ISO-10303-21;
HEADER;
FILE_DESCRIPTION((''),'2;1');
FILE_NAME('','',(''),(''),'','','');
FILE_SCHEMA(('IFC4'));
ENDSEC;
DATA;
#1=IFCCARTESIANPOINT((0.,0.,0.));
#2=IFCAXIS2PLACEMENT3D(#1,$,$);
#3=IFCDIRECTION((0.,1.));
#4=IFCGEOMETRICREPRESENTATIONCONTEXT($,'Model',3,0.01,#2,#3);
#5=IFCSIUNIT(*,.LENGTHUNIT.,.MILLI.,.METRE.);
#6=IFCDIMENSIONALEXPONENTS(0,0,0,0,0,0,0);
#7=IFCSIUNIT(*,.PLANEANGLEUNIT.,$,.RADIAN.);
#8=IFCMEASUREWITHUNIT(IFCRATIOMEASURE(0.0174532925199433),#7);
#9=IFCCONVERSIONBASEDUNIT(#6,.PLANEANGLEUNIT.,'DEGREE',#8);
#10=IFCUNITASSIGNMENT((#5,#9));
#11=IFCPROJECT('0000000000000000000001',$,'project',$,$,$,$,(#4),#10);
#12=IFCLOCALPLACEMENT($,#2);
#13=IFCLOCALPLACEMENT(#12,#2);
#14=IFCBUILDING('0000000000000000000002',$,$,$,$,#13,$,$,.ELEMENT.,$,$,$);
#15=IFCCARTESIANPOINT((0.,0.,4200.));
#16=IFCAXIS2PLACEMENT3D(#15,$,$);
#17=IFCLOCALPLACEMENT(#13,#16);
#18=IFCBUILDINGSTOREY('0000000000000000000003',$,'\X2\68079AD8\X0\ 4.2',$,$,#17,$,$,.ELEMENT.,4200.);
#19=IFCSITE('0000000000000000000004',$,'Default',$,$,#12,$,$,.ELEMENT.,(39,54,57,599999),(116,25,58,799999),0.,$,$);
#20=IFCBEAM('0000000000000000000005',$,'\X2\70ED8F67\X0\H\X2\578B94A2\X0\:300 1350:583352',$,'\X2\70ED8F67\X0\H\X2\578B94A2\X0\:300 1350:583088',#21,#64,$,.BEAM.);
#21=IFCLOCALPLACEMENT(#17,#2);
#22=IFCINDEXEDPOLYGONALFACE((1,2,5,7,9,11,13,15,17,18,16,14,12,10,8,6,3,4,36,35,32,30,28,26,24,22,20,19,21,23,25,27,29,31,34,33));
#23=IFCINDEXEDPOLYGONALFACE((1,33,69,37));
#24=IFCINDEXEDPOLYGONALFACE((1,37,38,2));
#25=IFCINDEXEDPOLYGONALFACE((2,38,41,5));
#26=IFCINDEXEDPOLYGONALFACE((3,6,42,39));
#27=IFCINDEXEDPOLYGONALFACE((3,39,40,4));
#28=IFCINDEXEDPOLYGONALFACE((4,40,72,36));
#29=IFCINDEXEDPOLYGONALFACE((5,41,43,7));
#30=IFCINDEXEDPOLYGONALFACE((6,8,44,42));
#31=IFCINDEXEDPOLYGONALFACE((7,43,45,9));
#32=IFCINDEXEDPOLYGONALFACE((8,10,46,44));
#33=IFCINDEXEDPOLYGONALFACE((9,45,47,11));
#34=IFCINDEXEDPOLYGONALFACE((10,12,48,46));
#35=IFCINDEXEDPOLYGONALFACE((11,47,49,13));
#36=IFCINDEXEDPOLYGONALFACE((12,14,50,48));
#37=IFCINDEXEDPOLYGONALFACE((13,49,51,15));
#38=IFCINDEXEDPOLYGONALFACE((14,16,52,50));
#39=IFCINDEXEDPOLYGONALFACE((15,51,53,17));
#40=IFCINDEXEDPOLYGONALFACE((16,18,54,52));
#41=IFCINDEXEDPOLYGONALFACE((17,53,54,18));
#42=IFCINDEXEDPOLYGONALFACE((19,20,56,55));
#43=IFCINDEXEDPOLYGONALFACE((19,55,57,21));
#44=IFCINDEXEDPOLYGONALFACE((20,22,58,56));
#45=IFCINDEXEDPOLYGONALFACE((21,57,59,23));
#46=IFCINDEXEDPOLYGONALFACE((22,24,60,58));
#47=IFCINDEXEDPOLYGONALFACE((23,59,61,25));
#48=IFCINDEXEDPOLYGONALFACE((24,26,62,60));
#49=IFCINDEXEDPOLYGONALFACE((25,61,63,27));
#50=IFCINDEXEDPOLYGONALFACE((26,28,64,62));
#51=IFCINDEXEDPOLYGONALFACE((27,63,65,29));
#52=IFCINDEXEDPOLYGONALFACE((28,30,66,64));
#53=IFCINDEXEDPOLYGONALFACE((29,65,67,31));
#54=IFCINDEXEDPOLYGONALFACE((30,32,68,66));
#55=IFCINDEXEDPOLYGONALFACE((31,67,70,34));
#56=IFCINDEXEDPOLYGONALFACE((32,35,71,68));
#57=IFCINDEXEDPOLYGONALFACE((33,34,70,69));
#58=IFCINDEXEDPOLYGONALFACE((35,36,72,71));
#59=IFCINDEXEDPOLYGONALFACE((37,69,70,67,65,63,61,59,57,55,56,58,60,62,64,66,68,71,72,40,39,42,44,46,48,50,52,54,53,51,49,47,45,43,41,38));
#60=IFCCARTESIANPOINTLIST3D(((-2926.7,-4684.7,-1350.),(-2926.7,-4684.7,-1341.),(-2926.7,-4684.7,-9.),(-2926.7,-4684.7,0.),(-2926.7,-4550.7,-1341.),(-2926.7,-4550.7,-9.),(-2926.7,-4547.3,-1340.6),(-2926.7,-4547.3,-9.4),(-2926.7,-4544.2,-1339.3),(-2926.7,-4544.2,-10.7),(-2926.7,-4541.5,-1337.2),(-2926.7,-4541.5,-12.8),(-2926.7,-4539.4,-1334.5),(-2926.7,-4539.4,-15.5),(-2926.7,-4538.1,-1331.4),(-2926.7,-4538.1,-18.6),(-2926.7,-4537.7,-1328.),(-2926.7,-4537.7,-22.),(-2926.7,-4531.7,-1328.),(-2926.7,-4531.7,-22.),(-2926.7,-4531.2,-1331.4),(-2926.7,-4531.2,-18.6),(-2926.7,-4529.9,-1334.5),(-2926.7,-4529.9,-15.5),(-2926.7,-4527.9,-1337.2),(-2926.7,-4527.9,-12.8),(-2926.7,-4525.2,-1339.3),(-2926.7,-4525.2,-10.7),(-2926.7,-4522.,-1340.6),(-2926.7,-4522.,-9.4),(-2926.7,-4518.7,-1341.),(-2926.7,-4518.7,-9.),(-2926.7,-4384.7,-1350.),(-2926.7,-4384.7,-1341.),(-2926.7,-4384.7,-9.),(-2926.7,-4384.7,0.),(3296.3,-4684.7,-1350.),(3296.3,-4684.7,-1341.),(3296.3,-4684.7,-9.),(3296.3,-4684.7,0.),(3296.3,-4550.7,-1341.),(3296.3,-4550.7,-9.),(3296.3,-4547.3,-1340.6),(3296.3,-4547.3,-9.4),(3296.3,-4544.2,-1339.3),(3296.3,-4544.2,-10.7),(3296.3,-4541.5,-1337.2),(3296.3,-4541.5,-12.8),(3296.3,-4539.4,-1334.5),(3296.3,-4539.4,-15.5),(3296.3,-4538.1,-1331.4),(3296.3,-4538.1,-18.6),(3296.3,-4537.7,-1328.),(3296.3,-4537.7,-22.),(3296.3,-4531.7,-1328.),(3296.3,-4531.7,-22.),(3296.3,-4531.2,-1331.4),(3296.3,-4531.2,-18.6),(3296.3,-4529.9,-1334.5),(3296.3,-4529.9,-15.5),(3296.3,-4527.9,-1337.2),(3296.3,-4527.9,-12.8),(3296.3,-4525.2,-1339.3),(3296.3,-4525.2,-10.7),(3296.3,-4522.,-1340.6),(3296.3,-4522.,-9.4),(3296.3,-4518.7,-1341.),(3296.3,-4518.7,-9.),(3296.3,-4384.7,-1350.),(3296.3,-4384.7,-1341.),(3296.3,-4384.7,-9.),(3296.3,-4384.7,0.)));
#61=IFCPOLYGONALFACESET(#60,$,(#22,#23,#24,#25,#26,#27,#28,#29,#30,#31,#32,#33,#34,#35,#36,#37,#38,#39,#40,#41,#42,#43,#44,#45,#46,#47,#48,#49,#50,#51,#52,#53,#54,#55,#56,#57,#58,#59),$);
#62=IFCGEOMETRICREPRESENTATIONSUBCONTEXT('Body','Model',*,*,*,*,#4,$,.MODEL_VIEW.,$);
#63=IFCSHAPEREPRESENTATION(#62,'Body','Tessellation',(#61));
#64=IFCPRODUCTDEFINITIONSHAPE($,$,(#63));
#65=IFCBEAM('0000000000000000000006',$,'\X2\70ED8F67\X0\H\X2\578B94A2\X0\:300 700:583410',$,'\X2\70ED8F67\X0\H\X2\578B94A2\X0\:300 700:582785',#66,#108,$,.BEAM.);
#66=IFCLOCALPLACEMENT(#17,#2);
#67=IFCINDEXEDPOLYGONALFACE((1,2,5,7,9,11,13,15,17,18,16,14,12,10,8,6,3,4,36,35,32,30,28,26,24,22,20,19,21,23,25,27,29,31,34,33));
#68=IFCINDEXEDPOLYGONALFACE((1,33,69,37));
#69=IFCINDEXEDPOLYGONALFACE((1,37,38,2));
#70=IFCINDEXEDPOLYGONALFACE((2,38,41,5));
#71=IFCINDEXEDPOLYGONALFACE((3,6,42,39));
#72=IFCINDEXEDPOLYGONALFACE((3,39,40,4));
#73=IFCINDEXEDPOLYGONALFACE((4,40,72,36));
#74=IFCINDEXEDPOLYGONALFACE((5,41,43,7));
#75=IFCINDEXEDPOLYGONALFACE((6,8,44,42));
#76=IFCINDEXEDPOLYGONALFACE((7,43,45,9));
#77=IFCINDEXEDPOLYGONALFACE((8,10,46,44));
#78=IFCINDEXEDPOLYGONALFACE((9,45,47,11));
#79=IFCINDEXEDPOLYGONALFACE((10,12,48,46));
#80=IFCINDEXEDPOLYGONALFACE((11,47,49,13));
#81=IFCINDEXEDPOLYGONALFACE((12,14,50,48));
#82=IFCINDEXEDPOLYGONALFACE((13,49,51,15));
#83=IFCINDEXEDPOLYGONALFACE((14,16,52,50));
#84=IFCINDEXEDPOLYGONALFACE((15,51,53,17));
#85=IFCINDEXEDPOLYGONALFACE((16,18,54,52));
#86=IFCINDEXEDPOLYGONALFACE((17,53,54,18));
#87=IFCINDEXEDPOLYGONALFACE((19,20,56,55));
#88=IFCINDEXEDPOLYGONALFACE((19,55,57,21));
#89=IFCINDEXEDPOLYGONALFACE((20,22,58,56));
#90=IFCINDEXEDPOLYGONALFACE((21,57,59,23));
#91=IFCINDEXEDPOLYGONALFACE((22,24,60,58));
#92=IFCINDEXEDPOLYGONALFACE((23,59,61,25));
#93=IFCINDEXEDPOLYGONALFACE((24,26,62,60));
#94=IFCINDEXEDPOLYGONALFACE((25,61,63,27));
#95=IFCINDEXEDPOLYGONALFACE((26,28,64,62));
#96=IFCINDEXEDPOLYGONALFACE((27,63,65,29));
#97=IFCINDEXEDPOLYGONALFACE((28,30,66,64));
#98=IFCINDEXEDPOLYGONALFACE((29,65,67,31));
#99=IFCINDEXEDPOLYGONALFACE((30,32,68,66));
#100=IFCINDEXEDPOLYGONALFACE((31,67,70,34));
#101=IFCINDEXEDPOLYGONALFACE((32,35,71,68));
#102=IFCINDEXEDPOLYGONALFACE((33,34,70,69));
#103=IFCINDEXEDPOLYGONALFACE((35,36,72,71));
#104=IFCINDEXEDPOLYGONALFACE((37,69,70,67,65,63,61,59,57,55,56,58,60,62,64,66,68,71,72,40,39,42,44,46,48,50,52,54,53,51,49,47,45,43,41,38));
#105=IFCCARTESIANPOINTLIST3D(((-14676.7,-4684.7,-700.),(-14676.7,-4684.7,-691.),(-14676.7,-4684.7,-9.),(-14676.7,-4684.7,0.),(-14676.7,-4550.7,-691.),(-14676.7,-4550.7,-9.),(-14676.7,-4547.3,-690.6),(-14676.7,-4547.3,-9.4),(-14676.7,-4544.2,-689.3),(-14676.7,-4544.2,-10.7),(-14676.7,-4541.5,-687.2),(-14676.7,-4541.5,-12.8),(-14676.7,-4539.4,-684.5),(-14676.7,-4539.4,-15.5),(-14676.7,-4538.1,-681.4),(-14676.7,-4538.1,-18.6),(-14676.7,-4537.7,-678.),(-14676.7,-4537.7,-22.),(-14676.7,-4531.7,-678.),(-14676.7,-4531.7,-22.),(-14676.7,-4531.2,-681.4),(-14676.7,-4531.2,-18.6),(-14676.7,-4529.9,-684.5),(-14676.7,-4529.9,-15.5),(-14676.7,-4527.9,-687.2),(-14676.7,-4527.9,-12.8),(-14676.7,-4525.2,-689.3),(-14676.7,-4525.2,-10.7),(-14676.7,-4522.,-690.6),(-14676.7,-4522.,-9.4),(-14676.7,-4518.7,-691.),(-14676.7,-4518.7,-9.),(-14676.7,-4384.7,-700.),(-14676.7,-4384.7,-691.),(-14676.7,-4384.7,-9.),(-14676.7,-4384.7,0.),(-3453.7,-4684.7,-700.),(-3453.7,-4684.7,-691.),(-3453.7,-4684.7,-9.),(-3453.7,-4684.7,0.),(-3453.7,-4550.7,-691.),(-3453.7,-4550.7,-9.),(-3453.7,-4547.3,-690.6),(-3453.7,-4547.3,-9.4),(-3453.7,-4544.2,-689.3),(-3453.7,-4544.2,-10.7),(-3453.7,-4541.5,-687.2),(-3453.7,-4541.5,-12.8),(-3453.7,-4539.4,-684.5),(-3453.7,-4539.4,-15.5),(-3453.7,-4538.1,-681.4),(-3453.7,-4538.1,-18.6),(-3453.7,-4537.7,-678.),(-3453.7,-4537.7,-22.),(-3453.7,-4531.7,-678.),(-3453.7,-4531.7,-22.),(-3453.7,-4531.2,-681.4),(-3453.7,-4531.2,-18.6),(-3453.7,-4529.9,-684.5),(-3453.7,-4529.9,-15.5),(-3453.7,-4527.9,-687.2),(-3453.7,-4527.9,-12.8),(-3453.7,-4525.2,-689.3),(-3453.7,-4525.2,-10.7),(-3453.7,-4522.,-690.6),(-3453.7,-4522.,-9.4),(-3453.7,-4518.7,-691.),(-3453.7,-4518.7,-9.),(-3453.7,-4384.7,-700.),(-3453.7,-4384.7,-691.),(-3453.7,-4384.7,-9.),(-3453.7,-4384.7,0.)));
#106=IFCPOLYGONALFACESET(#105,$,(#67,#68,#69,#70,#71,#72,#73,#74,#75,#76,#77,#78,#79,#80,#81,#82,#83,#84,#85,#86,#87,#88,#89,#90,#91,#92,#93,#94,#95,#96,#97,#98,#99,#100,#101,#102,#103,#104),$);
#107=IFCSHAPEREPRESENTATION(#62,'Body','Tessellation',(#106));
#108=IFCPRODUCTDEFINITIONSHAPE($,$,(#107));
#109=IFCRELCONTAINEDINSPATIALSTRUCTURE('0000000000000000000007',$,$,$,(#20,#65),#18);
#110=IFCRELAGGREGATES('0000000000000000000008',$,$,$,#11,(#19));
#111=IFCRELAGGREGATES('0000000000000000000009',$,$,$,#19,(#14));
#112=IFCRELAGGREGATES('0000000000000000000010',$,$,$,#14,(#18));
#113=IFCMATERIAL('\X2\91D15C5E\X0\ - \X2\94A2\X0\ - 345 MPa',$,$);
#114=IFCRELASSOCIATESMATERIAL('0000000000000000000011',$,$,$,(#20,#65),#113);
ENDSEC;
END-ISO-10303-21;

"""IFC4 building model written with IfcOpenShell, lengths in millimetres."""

from ifc_helpers import new_model, entity, si_unit, converted_unit, direction, frame, frame_2d, origin, place, context, subcontext, project, spatial, i_section, extrude, material, element, save


model = new_model("IFC4")

# Units and contexts
model_context = context("Model", 3, precision=0.01, world=origin(), true_north=direction((0.0, 1.0)))
body_context = subcontext(model_context, "Body", "Model", "MODEL_VIEW")
ifc_project = project(units=[si_unit("LENGTHUNIT", "METRE", prefix="MILLI"), converted_unit("PLANEANGLEUNIT", "DEGREE", entity("IfcRatioMeasure", 0.0174532925199433), si_unit("PLANEANGLEUNIT", "RADIAN"), dimensions=[0, 0, 0, 0, 0, 0, 0])], contexts=[model_context])

# Site, building, storey
site_placement = place(None, origin())
site = spatial("IfcSite", under=ifc_project, at=site_placement, Name="Default", CompositionType="ELEMENT", RefLatitude=(39, 54, 57, 599999), RefLongitude=(116, 25, 58, 799999), RefElevation=0.0)
building_placement = place(site_placement, origin())
building = spatial("IfcBuilding", under=site, at=building_placement, CompositionType="ELEMENT")
storey_placement = place(building_placement, frame((0.0, 0.0, 4200.0)))
storey = spatial("IfcBuildingStorey", under=building, at=storey_placement, Name="标高 4.2", CompositionType="ELEMENT", Elevation=4200.0)

# Beams
ifc_material_1 = material(Name="金属 - 钢 - 345 MPa")
beam_1_placement = place(storey_placement, frame((-2942.7, -4534.7, 0.0)))
element("IfcBeam", 1, at=beam_1_placement, inside=storey, material=ifc_material_1, Name="热轧H型钢:300 1350:583352", ObjectType="热轧H型钢:300 1350:583088", PredefinedType="BEAM", context=body_context, shape_type="SweptSolid", body=[
    extrude(i_section(OverallWidth=300.0, OverallDepth=1350.0, WebThickness=6.0, FlangeThickness=9.0, FilletRadius=13.0, at=frame_2d((0.0, 0.0), x_axis=(0.0, 1.0))), frame((16.0, 0.0, -675.0), z_axis=(1.0, 0.0, 0.0), x_axis=(0.0, 0.0, -1.0)), (0.0, 0.0, 1.0), 6223.0),
])
beam_2_placement = place(storey_placement, frame((-14692.7, -4534.7, 0.0)))
element("IfcBeam", 2, at=beam_2_placement, inside=storey, material=ifc_material_1, Name="热轧H型钢:300 700:583410", ObjectType="热轧H型钢:300 700:582785", PredefinedType="BEAM", context=body_context, shape_type="SweptSolid", body=[
    extrude(i_section(OverallWidth=300.0, OverallDepth=700.0, WebThickness=6.0, FlangeThickness=9.0, FilletRadius=13.0, at=frame_2d((0.0, 0.0), x_axis=(0.0, 1.0))), frame((16.0, 0.0, -350.0), z_axis=(1.0, 0.0, 0.0), x_axis=(0.0, 0.0, -1.0)), (0.0, 0.0, 1.0), 11223.0),
])

save(model, "model.ifc")
